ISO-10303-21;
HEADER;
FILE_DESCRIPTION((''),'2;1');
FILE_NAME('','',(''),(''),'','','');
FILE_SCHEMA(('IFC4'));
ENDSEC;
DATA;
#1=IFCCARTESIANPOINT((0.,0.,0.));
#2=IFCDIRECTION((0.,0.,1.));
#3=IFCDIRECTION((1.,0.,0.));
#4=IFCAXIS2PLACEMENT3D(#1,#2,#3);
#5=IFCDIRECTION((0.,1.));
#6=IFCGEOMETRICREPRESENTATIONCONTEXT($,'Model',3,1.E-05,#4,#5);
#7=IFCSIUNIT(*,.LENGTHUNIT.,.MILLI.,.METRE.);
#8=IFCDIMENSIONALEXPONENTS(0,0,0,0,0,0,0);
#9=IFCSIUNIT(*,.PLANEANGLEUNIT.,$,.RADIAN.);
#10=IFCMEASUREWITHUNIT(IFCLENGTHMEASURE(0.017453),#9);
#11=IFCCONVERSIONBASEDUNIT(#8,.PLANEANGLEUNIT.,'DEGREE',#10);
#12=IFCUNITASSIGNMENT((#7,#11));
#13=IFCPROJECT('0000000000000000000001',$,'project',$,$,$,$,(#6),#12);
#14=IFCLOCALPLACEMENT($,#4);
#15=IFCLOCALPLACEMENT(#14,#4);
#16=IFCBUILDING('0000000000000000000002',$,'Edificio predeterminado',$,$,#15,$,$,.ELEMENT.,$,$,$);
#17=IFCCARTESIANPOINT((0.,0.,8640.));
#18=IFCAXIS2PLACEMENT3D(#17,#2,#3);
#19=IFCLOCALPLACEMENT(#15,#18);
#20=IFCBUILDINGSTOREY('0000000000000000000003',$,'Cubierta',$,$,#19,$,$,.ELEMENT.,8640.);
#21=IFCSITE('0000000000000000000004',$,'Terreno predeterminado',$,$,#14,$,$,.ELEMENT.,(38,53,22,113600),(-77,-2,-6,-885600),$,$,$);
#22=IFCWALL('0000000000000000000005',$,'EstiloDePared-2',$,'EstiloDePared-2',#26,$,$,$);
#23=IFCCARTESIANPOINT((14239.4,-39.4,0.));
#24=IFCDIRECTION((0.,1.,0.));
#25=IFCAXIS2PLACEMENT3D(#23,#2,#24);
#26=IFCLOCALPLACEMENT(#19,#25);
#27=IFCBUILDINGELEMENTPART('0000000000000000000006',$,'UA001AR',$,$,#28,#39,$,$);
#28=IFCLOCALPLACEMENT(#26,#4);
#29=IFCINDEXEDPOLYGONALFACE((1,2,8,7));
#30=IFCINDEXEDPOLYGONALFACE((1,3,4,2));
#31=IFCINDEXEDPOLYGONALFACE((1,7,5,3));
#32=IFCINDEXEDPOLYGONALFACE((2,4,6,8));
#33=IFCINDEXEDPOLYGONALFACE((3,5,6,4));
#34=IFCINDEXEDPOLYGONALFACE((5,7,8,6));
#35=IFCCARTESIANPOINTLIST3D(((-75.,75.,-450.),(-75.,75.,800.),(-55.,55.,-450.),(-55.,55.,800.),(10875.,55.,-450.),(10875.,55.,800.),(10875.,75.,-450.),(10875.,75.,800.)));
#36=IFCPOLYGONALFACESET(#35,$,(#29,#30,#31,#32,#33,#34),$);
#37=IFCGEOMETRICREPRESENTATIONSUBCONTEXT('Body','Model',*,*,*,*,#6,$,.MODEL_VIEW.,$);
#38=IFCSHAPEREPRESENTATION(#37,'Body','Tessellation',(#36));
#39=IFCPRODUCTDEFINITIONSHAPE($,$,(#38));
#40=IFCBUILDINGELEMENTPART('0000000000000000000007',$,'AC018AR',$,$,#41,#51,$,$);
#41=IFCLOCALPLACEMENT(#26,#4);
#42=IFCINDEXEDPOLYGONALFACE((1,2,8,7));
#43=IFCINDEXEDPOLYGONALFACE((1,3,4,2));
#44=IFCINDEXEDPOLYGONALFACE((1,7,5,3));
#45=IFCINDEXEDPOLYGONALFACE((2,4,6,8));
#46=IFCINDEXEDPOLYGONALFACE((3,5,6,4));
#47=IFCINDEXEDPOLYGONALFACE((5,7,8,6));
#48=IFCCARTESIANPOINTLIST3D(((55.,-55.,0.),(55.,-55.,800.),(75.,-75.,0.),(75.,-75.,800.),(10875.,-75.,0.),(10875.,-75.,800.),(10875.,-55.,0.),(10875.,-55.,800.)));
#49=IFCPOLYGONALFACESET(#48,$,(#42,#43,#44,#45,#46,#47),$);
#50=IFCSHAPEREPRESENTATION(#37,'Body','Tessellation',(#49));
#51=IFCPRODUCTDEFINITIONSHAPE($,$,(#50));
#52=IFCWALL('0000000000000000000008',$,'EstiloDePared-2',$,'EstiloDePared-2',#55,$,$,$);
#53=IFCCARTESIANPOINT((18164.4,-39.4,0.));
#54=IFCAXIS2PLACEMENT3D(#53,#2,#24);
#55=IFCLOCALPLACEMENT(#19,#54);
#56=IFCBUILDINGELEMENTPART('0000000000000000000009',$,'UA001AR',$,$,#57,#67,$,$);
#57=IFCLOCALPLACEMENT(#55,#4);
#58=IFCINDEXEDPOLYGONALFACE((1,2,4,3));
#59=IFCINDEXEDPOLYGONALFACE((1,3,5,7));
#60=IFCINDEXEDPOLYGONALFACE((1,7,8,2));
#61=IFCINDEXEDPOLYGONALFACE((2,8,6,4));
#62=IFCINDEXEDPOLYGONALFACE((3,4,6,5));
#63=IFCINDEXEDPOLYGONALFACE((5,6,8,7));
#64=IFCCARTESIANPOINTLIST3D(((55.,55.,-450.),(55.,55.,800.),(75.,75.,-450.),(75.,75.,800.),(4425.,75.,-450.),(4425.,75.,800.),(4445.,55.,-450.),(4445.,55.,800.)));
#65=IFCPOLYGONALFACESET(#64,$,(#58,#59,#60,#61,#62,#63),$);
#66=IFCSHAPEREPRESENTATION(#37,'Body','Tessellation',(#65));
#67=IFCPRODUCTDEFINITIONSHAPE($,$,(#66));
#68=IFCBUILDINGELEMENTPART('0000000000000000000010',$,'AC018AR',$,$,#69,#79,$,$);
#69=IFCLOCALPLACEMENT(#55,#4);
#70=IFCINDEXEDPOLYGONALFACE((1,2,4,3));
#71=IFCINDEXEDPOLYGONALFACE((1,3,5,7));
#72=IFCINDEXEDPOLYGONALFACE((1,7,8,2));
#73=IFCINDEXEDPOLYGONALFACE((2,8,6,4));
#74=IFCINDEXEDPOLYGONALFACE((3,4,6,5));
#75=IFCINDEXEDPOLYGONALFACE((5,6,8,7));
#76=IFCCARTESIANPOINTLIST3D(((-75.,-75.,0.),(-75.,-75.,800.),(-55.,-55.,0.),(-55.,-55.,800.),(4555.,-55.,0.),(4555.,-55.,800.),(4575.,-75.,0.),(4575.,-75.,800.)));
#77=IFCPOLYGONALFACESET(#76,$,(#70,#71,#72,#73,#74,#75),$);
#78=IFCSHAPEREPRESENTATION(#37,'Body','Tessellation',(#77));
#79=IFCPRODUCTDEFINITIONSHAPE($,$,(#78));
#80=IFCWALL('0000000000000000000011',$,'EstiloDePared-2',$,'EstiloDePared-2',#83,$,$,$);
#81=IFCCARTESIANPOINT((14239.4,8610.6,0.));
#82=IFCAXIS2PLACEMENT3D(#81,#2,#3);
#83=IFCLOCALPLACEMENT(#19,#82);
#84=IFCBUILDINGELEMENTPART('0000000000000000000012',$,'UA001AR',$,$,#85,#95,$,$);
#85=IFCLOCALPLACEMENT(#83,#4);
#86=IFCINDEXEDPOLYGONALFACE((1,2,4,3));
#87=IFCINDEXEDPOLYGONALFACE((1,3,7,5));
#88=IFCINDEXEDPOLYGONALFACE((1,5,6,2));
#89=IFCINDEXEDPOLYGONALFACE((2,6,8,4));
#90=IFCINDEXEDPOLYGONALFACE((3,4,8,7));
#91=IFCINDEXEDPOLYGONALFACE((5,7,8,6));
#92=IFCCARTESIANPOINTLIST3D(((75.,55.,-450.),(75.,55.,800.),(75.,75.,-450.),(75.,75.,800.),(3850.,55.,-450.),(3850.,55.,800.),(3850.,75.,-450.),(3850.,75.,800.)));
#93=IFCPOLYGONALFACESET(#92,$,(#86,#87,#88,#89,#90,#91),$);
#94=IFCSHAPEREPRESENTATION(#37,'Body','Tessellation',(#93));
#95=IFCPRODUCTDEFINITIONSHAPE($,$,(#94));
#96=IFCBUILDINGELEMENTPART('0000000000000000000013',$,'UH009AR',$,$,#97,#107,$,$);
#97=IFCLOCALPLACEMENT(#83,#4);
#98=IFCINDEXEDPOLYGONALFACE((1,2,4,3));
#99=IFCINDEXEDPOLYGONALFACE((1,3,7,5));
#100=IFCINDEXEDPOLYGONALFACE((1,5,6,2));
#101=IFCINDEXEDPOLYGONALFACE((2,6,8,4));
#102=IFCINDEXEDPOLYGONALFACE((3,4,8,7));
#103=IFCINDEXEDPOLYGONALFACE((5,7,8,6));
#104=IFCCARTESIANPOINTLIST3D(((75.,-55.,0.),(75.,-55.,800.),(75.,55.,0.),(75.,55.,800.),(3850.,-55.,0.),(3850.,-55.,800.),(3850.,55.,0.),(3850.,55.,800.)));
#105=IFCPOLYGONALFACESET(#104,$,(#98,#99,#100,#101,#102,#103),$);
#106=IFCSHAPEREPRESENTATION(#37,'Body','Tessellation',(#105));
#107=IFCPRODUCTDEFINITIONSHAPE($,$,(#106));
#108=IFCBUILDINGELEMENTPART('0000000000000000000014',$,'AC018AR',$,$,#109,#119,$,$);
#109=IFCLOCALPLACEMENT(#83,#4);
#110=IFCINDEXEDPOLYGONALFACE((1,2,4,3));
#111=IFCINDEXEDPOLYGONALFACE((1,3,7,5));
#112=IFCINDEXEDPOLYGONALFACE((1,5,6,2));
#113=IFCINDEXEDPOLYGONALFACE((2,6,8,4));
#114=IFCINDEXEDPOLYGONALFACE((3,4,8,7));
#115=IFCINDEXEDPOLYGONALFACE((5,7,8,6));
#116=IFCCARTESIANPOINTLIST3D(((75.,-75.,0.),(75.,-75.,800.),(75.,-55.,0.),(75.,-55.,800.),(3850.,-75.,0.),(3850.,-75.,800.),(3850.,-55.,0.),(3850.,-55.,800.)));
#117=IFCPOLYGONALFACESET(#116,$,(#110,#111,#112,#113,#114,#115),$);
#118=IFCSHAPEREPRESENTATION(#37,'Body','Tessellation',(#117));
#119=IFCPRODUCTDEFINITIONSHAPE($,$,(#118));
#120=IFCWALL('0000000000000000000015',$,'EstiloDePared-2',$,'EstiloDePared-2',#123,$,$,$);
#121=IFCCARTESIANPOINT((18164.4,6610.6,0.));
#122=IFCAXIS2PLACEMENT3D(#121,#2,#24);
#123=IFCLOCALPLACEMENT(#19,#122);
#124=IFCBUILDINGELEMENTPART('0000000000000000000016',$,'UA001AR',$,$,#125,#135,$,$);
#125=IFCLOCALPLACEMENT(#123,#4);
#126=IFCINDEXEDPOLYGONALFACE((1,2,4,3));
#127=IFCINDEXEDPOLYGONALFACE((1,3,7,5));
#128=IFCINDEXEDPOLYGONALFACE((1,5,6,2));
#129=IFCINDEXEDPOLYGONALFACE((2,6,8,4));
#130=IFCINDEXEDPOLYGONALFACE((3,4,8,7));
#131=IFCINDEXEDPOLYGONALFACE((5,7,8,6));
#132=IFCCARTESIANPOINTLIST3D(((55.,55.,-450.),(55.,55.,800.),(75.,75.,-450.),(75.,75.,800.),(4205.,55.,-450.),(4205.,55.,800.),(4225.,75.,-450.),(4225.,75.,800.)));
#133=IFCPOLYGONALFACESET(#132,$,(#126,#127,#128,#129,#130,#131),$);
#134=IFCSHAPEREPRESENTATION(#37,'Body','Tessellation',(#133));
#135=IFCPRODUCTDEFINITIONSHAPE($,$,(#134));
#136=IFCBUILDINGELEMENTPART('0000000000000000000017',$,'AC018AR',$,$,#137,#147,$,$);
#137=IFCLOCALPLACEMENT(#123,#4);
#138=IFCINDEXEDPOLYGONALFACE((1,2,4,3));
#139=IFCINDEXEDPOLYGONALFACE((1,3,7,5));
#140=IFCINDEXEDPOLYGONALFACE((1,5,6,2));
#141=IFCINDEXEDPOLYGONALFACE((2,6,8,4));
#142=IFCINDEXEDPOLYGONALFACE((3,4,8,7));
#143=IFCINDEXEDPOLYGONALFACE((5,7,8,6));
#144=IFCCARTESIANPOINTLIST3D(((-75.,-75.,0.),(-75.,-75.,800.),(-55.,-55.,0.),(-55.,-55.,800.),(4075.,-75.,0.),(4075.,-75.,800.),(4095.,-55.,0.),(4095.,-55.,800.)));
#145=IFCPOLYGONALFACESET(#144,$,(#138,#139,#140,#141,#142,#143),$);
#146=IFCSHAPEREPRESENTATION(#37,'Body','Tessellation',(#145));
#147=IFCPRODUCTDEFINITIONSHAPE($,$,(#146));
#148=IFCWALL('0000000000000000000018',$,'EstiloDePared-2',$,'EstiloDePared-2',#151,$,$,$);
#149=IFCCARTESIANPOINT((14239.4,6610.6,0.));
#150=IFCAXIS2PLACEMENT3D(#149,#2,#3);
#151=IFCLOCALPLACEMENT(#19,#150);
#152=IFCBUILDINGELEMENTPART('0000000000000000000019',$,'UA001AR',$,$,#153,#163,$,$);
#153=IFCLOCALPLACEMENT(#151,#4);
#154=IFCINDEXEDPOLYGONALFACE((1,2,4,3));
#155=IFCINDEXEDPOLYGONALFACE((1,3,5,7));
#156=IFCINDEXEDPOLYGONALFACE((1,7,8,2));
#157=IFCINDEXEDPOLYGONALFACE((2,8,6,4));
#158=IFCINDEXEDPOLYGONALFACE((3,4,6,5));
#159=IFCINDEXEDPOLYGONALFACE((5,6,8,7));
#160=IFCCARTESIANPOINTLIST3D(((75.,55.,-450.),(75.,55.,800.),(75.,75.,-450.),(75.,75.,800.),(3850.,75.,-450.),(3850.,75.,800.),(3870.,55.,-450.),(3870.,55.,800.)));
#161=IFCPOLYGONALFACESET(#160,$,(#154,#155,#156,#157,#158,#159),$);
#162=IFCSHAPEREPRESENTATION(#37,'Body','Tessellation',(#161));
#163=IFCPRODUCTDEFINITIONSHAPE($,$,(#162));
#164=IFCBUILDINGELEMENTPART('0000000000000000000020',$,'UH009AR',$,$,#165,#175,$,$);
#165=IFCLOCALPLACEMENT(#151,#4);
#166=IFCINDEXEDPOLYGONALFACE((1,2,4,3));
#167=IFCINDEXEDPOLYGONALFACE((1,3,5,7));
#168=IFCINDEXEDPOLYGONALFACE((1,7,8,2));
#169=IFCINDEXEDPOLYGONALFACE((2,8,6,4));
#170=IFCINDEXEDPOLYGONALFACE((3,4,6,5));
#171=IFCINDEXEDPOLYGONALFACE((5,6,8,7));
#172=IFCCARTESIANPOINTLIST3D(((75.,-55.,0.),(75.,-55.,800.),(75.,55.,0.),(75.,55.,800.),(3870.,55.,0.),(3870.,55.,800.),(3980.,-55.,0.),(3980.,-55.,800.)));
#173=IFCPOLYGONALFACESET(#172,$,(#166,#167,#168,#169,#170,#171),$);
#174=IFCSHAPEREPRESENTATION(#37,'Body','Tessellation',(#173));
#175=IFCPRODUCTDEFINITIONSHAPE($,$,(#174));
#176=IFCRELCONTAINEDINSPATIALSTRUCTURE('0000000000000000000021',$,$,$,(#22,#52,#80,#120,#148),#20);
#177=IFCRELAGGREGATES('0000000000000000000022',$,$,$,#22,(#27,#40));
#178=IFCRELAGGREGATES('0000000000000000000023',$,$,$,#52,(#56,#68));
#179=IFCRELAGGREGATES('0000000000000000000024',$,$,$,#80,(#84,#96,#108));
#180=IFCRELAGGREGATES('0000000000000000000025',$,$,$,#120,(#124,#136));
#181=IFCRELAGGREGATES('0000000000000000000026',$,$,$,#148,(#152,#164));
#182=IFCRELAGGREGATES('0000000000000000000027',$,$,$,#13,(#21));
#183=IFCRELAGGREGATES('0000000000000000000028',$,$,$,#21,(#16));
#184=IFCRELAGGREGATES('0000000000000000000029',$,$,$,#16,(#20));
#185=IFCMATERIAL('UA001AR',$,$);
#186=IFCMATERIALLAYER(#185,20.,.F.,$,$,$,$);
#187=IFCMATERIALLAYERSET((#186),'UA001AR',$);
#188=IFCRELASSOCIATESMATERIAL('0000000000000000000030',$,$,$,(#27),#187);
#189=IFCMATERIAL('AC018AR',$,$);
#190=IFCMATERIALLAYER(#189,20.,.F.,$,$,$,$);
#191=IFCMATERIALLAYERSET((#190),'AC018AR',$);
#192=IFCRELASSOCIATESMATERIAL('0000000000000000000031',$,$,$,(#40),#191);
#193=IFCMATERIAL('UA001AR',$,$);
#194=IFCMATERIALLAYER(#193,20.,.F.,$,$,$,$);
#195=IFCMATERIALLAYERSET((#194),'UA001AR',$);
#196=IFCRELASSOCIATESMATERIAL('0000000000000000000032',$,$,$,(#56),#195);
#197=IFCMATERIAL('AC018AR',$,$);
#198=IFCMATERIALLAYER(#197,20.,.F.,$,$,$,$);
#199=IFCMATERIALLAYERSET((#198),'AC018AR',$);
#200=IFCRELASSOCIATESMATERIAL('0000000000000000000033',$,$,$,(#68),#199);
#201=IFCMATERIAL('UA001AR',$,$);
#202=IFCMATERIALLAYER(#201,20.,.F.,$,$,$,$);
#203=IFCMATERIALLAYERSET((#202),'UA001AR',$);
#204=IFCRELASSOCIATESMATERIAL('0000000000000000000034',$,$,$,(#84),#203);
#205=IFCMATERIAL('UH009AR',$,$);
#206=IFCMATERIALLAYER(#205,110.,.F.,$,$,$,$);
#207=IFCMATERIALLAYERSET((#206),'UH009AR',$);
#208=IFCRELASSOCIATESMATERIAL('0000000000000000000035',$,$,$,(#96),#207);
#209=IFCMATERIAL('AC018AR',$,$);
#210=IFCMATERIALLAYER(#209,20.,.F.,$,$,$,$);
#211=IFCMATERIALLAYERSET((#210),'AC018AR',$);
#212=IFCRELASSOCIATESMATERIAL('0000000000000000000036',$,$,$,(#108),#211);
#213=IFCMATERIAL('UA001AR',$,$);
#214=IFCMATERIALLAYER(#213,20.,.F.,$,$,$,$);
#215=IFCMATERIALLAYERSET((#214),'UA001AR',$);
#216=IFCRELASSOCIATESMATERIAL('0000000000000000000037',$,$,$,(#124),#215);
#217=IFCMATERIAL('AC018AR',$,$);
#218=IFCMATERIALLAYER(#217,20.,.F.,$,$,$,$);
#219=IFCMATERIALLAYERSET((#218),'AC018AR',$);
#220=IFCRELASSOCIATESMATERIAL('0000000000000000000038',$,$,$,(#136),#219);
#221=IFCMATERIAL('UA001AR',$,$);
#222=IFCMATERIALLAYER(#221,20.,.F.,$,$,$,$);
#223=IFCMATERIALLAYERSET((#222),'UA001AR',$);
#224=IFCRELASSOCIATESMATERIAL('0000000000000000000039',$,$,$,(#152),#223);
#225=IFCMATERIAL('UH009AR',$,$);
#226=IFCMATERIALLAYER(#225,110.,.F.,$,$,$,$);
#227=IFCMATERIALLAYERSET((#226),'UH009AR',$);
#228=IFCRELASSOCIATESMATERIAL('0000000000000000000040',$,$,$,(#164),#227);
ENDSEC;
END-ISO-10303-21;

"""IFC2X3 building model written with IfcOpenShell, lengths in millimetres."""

from ifc_helpers import new_model, entity, si_unit, converted_unit, direction, frame, origin_with_axes, place, context, subcontext, project, spatial, polyline, outline, extrude, material, layer, layer_set, layer_usage, element, aggregate, save


model = new_model("IFC2X3")

# Units and contexts
model_context = context("Model", 3, precision=1e-05, world=origin_with_axes(), true_north=direction((0.0, 1.0)))
body_context = subcontext(model_context, "Body", "Model", "MODEL_VIEW")
ifc_project = project(units=[si_unit("LENGTHUNIT", "METRE", prefix="MILLI"), converted_unit("PLANEANGLEUNIT", "DEGREE", entity("IfcLengthMeasure", 0.017453), si_unit("PLANEANGLEUNIT", "RADIAN"), dimensions=[0, 0, 0, 0, 0, 0, 0])], contexts=[model_context])

# Site, building, storey
site_placement = place(None, origin_with_axes())
site = spatial("IfcSite", under=ifc_project, at=site_placement, Name="Terreno predeterminado", CompositionType="ELEMENT", RefLatitude=(38, 53, 22, 113600), RefLongitude=(-77, -2, -6, -885600))
building_placement = place(site_placement, origin_with_axes())
building = spatial("IfcBuilding", under=site, at=building_placement, Name="Edificio predeterminado", CompositionType="ELEMENT")
storey_placement = place(building_placement, frame((0.0, 0.0, 8640.0), z_axis=(0.0, 0.0, 1.0), x_axis=(1.0, 0.0, 0.0)))
storey = spatial("IfcBuildingStorey", under=building, at=storey_placement, Name="Cubierta", CompositionType="ELEMENT", Elevation=8640.0)

# Walls, building element parts
wall_1_placement = place(storey_placement, frame((14239.4, -39.4, 0.0), z_axis=(0.0, 0.0, 1.0), x_axis=(0.0, 1.0, 0.0)))
wall_1 = element("IfcWall", 1, at=wall_1_placement, inside=storey, Name="EstiloDePared-2", ObjectType="EstiloDePared-2")
ifc_material_1 = material(Name="UA001AR")
ifc_layer_1 = layer(ifc_material_1, 20.0, ventilated=False)
ifc_layer_set_1 = layer_set([ifc_layer_1], Name="UA001AR")
ifc_layer_usage_1 = layer_usage(ifc_layer_set_1, "AXIS2", "NEGATIVE", -75.0)
building_element_part_1_placement = place(wall_1_placement, origin_with_axes())
building_element_part_1 = element("IfcBuildingElementPart", 2, at=building_element_part_1_placement, material=ifc_layer_usage_1, Name="UA001AR", context=body_context, shape_type="SweptSolid", body=[
    extrude(outline(polyline([(10875.0, 75.0), (10875.0, 55.0), (-55.0, 55.0), (-75.0, 75.0), (10875.0, 75.0)])), frame((0.0, 0.0, -450.0), z_axis=(0.0, 0.0, 1.0), x_axis=(1.0, 0.0, 0.0)), (0.0, 0.0, 1.0), 1250.0),
])
ifc_material_2 = material(Name="AC018AR")
ifc_layer_2 = layer(ifc_material_2, 20.0, ventilated=False)
ifc_layer_set_2 = layer_set([ifc_layer_2], Name="AC018AR")
ifc_layer_usage_2 = layer_usage(ifc_layer_set_2, "AXIS2", "NEGATIVE", 55.0)
building_element_part_2_placement = place(wall_1_placement, origin_with_axes())
building_element_part_2 = element("IfcBuildingElementPart", 3, at=building_element_part_2_placement, material=ifc_layer_usage_2, Name="AC018AR", context=body_context, shape_type="SweptSolid", body=[
    extrude(outline(polyline([(10875.0, -55.0), (10875.0, -75.0), (75.0, -75.0), (55.0, -55.0), (10875.0, -55.0)])), origin_with_axes(), (0.0, 0.0, 1.0), 800.0),
])
aggregate(wall_1, [building_element_part_1, building_element_part_2])
wall_2_placement = place(storey_placement, frame((18164.4, -39.4, 0.0), z_axis=(0.0, 0.0, 1.0), x_axis=(0.0, 1.0, 0.0)))
wall_2 = element("IfcWall", 4, at=wall_2_placement, inside=storey, Name="EstiloDePared-2", ObjectType="EstiloDePared-2")
ifc_material_3 = material(Name="UA001AR")
ifc_layer_3 = layer(ifc_material_3, 20.0, ventilated=False)
ifc_layer_set_3 = layer_set([ifc_layer_3], Name="UA001AR")
ifc_layer_usage_3 = layer_usage(ifc_layer_set_3, "AXIS2", "NEGATIVE", -75.0)
building_element_part_3_placement = place(wall_2_placement, origin_with_axes())
building_element_part_3 = element("IfcBuildingElementPart", 5, at=building_element_part_3_placement, material=ifc_layer_usage_3, Name="UA001AR", context=body_context, shape_type="SweptSolid", body=[
    extrude(outline(polyline([(4425.0, 75.0), (4445.0, 55.0), (55.0, 55.0), (75.0, 75.0), (4425.0, 75.0)])), frame((0.0, 0.0, -450.0), z_axis=(0.0, 0.0, 1.0), x_axis=(1.0, 0.0, 0.0)), (0.0, 0.0, 1.0), 1250.0),
])
ifc_material_4 = material(Name="AC018AR")
ifc_layer_4 = layer(ifc_material_4, 20.0, ventilated=False)
ifc_layer_set_4 = layer_set([ifc_layer_4], Name="AC018AR")
ifc_layer_usage_4 = layer_usage(ifc_layer_set_4, "AXIS2", "NEGATIVE", 55.0)
building_element_part_4_placement = place(wall_2_placement, origin_with_axes())
building_element_part_4 = element("IfcBuildingElementPart", 6, at=building_element_part_4_placement, material=ifc_layer_usage_4, Name="AC018AR", context=body_context, shape_type="SweptSolid", body=[
    extrude(outline(polyline([(4555.0, -55.0), (4575.0, -75.0), (-75.0, -75.0), (-55.0, -55.0), (4555.0, -55.0)])), origin_with_axes(), (0.0, 0.0, 1.0), 800.0),
])
aggregate(wall_2, [building_element_part_3, building_element_part_4])
wall_3_placement = place(storey_placement, frame((14239.4, 8610.6, 0.0), z_axis=(0.0, 0.0, 1.0), x_axis=(1.0, 0.0, 0.0)))
wall_3 = element("IfcWall", 7, at=wall_3_placement, inside=storey, Name="EstiloDePared-2", ObjectType="EstiloDePared-2")
ifc_material_5 = material(Name="UA001AR")
ifc_layer_5 = layer(ifc_material_5, 20.0, ventilated=False)
ifc_layer_set_5 = layer_set([ifc_layer_5], Name="UA001AR")
ifc_layer_usage_5 = layer_usage(ifc_layer_set_5, "AXIS2", "NEGATIVE", -75.0)
building_element_part_5_placement = place(wall_3_placement, origin_with_axes())
building_element_part_5 = element("IfcBuildingElementPart", 8, at=building_element_part_5_placement, material=ifc_layer_usage_5, Name="UA001AR", context=body_context, shape_type="SweptSolid", body=[
    extrude(outline(polyline([(3850.0, 75.0), (3850.0, 55.0), (75.0, 55.0), (75.0, 75.0), (3850.0, 75.0)])), frame((0.0, 0.0, -450.0), z_axis=(0.0, 0.0, 1.0), x_axis=(1.0, 0.0, 0.0)), (0.0, 0.0, 1.0), 1250.0),
])
ifc_material_6 = material(Name="UH009AR")
ifc_layer_6 = layer(ifc_material_6, 110.0, ventilated=False)
ifc_layer_set_6 = layer_set([ifc_layer_6], Name="UH009AR")
ifc_layer_usage_6 = layer_usage(ifc_layer_set_6, "AXIS2", "NEGATIVE", -55.0)
building_element_part_6_placement = place(wall_3_placement, origin_with_axes())
building_element_part_6 = element("IfcBuildingElementPart", 9, at=building_element_part_6_placement, material=ifc_layer_usage_6, Name="UH009AR", context=body_context, shape_type="SweptSolid", body=[
    extrude(outline(polyline([(3850.0, 55.0), (3850.0, -55.0), (75.0, -55.0), (75.0, 55.0), (3850.0, 55.0)])), origin_with_axes(), (0.0, 0.0, 1.0), 800.0),
])
ifc_material_7 = material(Name="AC018AR")
ifc_layer_7 = layer(ifc_material_7, 20.0, ventilated=False)
ifc_layer_set_7 = layer_set([ifc_layer_7], Name="AC018AR")
ifc_layer_usage_7 = layer_usage(ifc_layer_set_7, "AXIS2", "NEGATIVE", 55.0)
building_element_part_7_placement = place(wall_3_placement, origin_with_axes())
building_element_part_7 = element("IfcBuildingElementPart", 10, at=building_element_part_7_placement, material=ifc_layer_usage_7, Name="AC018AR", context=body_context, shape_type="SweptSolid", body=[
    extrude(outline(polyline([(3850.0, -55.0), (3850.0, -75.0), (75.0, -75.0), (75.0, -55.0), (3850.0, -55.0)])), origin_with_axes(), (0.0, 0.0, 1.0), 800.0),
])
aggregate(wall_3, [building_element_part_5, building_element_part_6, building_element_part_7])
wall_4_placement = place(storey_placement, frame((18164.4, 6610.6, 0.0), z_axis=(0.0, 0.0, 1.0), x_axis=(0.0, 1.0, 0.0)))
wall_4 = element("IfcWall", 11, at=wall_4_placement, inside=storey, Name="EstiloDePared-2", ObjectType="EstiloDePared-2")
ifc_material_8 = material(Name="UA001AR")
ifc_layer_8 = layer(ifc_material_8, 20.0, ventilated=False)
ifc_layer_set_8 = layer_set([ifc_layer_8], Name="UA001AR")
ifc_layer_usage_8 = layer_usage(ifc_layer_set_8, "AXIS2", "NEGATIVE", -75.0)
building_element_part_8_placement = place(wall_4_placement, origin_with_axes())
building_element_part_8 = element("IfcBuildingElementPart", 12, at=building_element_part_8_placement, material=ifc_layer_usage_8, Name="UA001AR", context=body_context, shape_type="SweptSolid", body=[
    extrude(outline(polyline([(4225.0, 75.0), (4205.0, 55.0), (55.0, 55.0), (75.0, 75.0), (4225.0, 75.0)])), frame((0.0, 0.0, -450.0), z_axis=(0.0, 0.0, 1.0), x_axis=(1.0, 0.0, 0.0)), (0.0, 0.0, 1.0), 1250.0),
])
ifc_material_9 = material(Name="AC018AR")
ifc_layer_9 = layer(ifc_material_9, 20.0, ventilated=False)
ifc_layer_set_9 = layer_set([ifc_layer_9], Name="AC018AR")
ifc_layer_usage_9 = layer_usage(ifc_layer_set_9, "AXIS2", "NEGATIVE", 55.0)
building_element_part_9_placement = place(wall_4_placement, origin_with_axes())
building_element_part_9 = element("IfcBuildingElementPart", 13, at=building_element_part_9_placement, material=ifc_layer_usage_9, Name="AC018AR", context=body_context, shape_type="SweptSolid", body=[
    extrude(outline(polyline([(4095.0, -55.0), (4075.0, -75.0), (-75.0, -75.0), (-55.0, -55.0), (4095.0, -55.0)])), origin_with_axes(), (0.0, 0.0, 1.0), 800.0),
])
aggregate(wall_4, [building_element_part_8, building_element_part_9])
wall_5_placement = place(storey_placement, frame((14239.4, 6610.6, 0.0), z_axis=(0.0, 0.0, 1.0), x_axis=(1.0, 0.0, 0.0)))
wall_5 = element("IfcWall", 14, at=wall_5_placement, inside=storey, Name="EstiloDePared-2", ObjectType="EstiloDePared-2")
ifc_material_10 = material(Name="UA001AR")
ifc_layer_10 = layer(ifc_material_10, 20.0, ventilated=False)
ifc_layer_set_10 = layer_set([ifc_layer_10], Name="UA001AR")
ifc_layer_usage_10 = layer_usage(ifc_layer_set_10, "AXIS2", "NEGATIVE", -75.0)
building_element_part_10_placement = place(wall_5_placement, origin_with_axes())
building_element_part_10 = element("IfcBuildingElementPart", 15, at=building_element_part_10_placement, material=ifc_layer_usage_10, Name="UA001AR", context=body_context, shape_type="SweptSolid", body=[
    extrude(outline(polyline([(3850.0, 75.0), (3870.0, 55.0), (75.0, 55.0), (75.0, 75.0), (3850.0, 75.0)])), frame((0.0, 0.0, -450.0), z_axis=(0.0, 0.0, 1.0), x_axis=(1.0, 0.0, 0.0)), (0.0, 0.0, 1.0), 1250.0),
])
ifc_material_11 = material(Name="UH009AR")
ifc_layer_11 = layer(ifc_material_11, 110.0, ventilated=False)
ifc_layer_set_11 = layer_set([ifc_layer_11], Name="UH009AR")
ifc_layer_usage_11 = layer_usage(ifc_layer_set_11, "AXIS2", "NEGATIVE", -55.0)
building_element_part_11_placement = place(wall_5_placement, origin_with_axes())
building_element_part_11 = element("IfcBuildingElementPart", 16, at=building_element_part_11_placement, material=ifc_layer_usage_11, Name="UH009AR", context=body_context, shape_type="SweptSolid", body=[
    extrude(outline(polyline([(3870.0, 55.0), (3980.0, -55.0), (75.0, -55.0), (75.0, 55.0), (3870.0, 55.0)])), origin_with_axes(), (0.0, 0.0, 1.0), 800.0),
])
aggregate(wall_5, [building_element_part_10, building_element_part_11])

save(model, "model.ifc")
